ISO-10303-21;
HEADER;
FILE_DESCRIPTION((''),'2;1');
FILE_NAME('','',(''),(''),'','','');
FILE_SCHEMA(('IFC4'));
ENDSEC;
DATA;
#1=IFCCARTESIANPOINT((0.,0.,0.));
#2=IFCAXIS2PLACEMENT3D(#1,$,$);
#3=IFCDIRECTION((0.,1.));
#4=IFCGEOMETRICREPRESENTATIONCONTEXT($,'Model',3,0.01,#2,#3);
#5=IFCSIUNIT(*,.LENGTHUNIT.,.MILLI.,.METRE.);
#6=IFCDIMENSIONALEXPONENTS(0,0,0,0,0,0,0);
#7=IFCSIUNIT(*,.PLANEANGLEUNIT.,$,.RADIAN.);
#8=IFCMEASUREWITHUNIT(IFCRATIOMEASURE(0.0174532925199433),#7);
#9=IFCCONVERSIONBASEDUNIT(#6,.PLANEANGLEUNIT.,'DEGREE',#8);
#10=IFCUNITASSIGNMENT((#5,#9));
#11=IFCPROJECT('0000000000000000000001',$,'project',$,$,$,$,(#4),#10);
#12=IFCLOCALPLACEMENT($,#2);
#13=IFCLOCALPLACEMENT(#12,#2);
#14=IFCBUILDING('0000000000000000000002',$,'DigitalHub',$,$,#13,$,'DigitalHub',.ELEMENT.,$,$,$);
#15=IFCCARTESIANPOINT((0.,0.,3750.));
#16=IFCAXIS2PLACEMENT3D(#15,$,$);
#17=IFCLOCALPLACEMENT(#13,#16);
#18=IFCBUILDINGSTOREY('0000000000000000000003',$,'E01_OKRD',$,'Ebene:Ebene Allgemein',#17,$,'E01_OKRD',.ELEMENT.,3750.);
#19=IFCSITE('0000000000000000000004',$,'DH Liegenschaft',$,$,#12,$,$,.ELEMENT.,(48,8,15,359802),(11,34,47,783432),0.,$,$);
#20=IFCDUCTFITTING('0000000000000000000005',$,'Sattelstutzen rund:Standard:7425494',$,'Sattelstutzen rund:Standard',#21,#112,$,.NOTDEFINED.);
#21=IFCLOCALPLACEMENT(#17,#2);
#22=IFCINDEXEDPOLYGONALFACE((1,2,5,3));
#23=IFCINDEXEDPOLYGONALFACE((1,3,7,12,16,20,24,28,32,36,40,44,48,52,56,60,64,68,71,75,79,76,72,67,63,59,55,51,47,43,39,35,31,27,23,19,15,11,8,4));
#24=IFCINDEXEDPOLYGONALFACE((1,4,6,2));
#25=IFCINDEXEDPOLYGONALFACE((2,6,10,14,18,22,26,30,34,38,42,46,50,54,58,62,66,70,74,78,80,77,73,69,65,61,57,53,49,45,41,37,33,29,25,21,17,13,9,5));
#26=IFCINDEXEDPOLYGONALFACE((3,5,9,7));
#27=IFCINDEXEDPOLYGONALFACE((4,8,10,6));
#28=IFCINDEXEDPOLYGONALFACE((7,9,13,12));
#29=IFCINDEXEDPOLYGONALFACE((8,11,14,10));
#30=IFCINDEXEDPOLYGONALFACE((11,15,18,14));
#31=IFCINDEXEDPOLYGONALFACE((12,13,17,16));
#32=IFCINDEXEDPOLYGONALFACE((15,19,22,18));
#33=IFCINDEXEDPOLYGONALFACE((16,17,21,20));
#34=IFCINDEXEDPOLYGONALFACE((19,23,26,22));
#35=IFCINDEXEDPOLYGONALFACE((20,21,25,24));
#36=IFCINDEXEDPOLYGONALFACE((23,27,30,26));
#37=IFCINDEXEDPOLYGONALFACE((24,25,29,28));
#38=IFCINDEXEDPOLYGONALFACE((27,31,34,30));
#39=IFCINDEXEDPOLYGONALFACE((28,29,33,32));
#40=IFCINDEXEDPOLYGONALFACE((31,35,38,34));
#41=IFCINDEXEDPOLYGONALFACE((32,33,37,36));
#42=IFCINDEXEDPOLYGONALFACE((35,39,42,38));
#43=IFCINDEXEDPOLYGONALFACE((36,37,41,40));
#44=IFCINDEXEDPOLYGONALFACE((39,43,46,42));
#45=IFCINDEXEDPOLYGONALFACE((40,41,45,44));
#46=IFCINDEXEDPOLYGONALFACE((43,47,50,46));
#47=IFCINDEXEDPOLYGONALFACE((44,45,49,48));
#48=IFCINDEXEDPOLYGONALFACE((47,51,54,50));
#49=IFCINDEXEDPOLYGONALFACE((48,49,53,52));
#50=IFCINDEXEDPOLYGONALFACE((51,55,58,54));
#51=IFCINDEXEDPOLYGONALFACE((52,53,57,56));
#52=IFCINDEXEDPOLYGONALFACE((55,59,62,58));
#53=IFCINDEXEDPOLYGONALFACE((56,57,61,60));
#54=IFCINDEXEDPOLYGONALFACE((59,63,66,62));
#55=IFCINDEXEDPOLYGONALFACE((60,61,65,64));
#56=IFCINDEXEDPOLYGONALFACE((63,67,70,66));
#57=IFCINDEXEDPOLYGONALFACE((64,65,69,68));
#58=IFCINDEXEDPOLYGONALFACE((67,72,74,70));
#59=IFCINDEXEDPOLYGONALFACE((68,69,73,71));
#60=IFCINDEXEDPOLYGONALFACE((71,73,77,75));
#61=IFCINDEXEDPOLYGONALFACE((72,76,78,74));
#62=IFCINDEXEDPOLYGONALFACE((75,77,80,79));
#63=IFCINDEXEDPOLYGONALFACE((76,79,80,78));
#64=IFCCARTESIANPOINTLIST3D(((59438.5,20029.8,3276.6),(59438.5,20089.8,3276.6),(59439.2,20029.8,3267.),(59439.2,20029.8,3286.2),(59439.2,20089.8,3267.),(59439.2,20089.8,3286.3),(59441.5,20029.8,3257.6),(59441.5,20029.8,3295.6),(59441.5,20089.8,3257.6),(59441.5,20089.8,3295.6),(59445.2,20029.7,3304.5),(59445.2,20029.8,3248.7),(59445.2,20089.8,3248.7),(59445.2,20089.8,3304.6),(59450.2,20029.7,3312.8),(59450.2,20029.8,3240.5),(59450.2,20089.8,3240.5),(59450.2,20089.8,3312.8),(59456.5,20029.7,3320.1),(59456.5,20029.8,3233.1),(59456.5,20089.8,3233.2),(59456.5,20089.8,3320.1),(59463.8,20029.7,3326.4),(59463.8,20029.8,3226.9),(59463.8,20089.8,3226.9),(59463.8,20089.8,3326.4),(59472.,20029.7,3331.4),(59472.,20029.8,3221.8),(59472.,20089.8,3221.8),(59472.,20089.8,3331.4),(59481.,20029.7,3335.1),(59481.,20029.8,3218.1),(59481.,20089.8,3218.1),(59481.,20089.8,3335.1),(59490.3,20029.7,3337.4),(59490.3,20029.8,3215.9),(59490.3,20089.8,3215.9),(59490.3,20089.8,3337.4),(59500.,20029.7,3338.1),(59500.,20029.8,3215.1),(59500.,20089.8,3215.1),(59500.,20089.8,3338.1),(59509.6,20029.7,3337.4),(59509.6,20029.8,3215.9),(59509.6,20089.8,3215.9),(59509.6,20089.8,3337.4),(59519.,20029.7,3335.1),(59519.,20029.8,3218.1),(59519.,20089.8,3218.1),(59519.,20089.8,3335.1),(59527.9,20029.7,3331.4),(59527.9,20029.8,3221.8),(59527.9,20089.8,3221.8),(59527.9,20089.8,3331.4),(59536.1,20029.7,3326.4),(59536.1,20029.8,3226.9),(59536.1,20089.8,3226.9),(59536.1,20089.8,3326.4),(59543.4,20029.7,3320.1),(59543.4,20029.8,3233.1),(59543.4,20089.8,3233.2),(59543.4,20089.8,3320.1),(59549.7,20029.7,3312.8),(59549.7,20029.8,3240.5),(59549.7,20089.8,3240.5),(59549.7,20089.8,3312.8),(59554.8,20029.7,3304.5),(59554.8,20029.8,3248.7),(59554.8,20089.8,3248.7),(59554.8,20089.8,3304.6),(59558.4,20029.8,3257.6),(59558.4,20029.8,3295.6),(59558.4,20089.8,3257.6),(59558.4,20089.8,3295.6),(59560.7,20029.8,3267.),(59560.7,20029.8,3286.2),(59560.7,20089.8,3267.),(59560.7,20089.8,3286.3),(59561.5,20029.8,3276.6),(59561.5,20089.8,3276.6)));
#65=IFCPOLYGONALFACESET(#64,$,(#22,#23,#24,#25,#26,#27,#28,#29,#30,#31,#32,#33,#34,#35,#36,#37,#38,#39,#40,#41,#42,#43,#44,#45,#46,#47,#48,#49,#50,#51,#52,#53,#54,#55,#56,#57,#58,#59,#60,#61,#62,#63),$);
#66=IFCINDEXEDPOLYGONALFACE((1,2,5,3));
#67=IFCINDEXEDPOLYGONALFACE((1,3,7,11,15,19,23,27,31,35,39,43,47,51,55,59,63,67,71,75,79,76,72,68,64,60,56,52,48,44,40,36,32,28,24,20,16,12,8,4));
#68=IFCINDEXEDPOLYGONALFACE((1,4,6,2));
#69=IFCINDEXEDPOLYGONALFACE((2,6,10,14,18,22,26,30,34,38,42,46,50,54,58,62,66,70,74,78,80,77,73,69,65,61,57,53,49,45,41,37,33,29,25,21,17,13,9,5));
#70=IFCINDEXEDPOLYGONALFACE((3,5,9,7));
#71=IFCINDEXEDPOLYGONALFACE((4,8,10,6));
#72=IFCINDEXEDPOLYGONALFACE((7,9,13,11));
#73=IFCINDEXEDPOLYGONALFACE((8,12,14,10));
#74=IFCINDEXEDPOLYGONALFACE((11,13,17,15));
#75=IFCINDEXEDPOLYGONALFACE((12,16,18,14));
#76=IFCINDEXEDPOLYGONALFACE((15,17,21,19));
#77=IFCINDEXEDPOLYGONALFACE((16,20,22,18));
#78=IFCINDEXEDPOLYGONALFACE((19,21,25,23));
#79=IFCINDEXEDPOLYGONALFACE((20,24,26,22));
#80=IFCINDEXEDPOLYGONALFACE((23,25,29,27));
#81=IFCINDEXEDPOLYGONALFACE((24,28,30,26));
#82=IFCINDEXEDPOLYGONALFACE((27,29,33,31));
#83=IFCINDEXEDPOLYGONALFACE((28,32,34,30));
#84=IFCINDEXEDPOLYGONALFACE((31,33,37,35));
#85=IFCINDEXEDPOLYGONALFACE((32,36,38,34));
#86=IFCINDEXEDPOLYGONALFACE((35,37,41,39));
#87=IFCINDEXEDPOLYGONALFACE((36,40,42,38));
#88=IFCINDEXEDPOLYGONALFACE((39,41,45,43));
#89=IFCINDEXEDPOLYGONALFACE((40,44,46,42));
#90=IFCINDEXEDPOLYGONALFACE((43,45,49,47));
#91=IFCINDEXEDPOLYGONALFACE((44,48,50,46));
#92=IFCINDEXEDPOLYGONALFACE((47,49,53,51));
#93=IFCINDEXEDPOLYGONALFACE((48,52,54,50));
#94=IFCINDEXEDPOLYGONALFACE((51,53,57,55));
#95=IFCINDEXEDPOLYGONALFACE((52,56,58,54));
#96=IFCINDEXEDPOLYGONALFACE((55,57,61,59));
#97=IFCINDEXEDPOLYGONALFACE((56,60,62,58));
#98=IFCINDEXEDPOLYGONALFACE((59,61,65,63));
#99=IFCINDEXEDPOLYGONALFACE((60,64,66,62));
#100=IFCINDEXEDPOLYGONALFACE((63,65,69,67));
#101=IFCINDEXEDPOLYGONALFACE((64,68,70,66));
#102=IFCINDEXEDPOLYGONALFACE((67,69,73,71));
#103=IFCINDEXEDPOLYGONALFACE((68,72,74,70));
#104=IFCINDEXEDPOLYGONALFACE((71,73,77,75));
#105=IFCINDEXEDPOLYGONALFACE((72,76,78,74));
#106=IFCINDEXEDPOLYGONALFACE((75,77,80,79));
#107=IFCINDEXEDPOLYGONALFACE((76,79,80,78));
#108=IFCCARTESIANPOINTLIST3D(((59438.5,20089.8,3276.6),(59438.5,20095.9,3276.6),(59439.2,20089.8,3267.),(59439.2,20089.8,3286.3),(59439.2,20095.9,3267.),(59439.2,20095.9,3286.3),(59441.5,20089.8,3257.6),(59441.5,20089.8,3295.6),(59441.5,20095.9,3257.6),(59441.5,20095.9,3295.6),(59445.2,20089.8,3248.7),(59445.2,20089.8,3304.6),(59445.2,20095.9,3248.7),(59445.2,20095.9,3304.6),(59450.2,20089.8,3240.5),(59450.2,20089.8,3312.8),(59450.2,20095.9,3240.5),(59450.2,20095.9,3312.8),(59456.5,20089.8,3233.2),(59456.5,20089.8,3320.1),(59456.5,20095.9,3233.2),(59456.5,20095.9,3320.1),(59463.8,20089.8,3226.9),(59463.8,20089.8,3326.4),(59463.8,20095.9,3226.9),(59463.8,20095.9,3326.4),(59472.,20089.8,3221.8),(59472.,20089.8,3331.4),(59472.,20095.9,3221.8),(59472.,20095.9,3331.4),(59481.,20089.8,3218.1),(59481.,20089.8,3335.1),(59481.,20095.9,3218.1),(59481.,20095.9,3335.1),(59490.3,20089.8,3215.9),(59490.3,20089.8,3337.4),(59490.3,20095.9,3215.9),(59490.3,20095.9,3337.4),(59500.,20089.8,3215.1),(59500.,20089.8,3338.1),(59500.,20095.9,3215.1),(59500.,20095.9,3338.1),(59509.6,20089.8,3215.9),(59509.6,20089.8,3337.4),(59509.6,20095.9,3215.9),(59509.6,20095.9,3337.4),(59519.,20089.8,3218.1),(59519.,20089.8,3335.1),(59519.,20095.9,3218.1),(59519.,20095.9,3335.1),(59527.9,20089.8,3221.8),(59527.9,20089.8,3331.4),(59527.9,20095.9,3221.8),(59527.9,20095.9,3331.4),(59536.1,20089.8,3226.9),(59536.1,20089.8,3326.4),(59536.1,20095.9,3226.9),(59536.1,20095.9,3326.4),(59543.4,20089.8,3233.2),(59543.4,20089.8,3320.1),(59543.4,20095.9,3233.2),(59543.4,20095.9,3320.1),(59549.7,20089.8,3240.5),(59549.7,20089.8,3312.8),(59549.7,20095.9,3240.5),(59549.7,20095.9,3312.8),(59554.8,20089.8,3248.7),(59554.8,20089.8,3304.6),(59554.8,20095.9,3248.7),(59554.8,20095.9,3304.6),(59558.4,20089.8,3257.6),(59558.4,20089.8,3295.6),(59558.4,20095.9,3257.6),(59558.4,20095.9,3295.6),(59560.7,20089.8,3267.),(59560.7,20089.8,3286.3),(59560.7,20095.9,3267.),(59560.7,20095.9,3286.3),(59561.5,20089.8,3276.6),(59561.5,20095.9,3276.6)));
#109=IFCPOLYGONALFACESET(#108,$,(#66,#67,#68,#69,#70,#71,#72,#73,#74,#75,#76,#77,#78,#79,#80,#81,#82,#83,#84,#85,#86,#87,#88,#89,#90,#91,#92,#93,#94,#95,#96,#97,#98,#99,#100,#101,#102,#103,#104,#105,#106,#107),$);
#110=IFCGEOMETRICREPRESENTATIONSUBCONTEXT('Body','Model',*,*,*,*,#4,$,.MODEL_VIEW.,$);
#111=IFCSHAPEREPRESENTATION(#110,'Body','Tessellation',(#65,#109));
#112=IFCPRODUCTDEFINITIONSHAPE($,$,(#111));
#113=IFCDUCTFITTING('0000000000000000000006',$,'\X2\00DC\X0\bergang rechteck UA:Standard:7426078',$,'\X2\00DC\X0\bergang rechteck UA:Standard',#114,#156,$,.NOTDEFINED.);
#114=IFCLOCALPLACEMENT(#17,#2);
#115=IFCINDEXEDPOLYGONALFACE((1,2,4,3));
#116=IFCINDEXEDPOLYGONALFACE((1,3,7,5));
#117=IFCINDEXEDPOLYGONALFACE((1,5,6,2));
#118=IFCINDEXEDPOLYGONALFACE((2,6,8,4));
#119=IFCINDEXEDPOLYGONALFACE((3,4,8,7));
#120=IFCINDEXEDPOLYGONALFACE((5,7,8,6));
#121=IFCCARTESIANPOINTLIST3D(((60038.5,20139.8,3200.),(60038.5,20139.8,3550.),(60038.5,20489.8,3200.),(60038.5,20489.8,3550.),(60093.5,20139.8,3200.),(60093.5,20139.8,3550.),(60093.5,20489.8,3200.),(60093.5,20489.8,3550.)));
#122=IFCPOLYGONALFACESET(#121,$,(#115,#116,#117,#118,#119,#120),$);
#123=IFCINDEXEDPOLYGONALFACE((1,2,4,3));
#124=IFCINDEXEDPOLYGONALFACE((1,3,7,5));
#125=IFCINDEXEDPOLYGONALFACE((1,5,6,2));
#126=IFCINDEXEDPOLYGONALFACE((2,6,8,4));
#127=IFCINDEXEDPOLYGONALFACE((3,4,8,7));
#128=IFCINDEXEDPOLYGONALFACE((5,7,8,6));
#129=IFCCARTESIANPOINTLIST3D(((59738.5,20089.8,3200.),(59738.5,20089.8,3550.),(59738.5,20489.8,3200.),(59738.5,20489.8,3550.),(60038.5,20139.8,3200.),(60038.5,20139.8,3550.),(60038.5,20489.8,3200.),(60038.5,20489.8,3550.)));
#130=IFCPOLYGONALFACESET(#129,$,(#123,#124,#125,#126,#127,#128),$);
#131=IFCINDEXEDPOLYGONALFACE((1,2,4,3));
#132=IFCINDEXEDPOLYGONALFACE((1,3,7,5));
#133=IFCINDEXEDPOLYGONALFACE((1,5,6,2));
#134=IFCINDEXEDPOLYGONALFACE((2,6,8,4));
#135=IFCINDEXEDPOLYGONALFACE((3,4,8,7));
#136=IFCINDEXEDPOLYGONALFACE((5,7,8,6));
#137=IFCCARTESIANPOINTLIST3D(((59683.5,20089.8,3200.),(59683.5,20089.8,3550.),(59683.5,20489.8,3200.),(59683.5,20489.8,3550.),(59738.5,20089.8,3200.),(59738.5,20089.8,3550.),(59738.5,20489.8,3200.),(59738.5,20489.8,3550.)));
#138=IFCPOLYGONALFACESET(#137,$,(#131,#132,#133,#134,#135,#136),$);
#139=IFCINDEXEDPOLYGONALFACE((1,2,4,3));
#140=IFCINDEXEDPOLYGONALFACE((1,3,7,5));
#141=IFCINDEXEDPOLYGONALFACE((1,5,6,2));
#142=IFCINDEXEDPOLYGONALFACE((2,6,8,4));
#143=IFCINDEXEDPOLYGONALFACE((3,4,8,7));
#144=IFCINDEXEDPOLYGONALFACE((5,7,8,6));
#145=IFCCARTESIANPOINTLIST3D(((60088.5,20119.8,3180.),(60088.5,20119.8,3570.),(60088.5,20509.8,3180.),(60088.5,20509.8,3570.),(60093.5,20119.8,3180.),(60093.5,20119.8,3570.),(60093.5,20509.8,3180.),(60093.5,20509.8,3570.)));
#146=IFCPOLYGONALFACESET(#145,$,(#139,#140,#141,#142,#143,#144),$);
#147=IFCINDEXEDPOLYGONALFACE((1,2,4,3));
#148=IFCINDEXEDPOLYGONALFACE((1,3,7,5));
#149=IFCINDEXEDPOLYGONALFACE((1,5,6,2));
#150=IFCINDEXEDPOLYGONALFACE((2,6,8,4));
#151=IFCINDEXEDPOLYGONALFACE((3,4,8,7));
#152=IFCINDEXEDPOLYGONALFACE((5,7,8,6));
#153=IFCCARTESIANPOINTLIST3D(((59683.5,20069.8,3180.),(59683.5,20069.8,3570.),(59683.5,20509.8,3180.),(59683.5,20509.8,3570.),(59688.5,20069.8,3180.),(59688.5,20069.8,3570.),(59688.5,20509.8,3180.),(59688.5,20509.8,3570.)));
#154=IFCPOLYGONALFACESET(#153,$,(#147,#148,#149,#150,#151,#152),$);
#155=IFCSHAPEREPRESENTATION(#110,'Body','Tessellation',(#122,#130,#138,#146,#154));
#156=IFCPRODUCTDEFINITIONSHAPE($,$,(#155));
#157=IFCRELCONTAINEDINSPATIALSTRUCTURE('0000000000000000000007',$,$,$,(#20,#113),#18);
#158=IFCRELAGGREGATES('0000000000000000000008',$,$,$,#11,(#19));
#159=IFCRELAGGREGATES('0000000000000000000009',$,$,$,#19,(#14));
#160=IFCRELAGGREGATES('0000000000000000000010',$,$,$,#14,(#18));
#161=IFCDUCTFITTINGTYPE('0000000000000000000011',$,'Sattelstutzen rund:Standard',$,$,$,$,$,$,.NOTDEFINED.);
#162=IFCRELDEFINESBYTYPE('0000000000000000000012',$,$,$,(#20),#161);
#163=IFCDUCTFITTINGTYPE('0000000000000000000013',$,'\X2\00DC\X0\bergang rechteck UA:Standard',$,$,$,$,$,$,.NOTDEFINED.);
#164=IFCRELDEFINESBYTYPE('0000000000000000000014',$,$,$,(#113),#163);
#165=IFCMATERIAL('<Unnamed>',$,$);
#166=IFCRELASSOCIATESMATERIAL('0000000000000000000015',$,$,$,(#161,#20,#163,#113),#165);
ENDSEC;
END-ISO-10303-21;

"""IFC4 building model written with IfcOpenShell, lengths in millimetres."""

from ifc_helpers import new_model, entity, si_unit, converted_unit, direction, frame, origin, place, context, subcontext, project, spatial, indexed_curve, outline, extrude, source, transform, mapped, material, type_object, type_shapes, element, save


model = new_model("IFC4")

# Units and contexts
model_context = context("Model", 3, precision=0.01, world=origin(), true_north=direction((0.0, 1.0)))
body_context = subcontext(model_context, "Body", "Model", "MODEL_VIEW")
ifc_project = project(units=[si_unit("LENGTHUNIT", "METRE", prefix="MILLI"), converted_unit("PLANEANGLEUNIT", "DEGREE", entity("IfcRatioMeasure", 0.0174532925199433), si_unit("PLANEANGLEUNIT", "RADIAN"), dimensions=[0, 0, 0, 0, 0, 0, 0])], contexts=[model_context])

# Site, building, storey
site_placement = place(None, origin())
site = spatial("IfcSite", under=ifc_project, at=site_placement, Name="DH Liegenschaft", CompositionType="ELEMENT", RefLatitude=(48, 8, 15, 359802), RefLongitude=(11, 34, 47, 783432), RefElevation=0.0)
building_placement = place(site_placement, origin())
building = spatial("IfcBuilding", under=site, at=building_placement, Name="DigitalHub", LongName="DigitalHub", CompositionType="ELEMENT")
storey_placement = place(building_placement, frame((0.0, 0.0, 3750.0)))
storey = spatial("IfcBuildingStorey", under=building, at=storey_placement, Name="E01_OKRD", ObjectType="Ebene:Ebene Allgemein", LongName="E01_OKRD", CompositionType="ELEMENT", Elevation=3750.0)

# Shared definitions
ifc_material_1 = material(Name="<Unnamed>")

# Duct fittings
duct_fitting_type_1 = type_object("IfcDuctFittingType", Name="Sattelstutzen rund:Standard", PredefinedType="NOTDEFINED", material=ifc_material_1)
shared_shape_1 = source(origin(), body_context, "Body", "SweptSolid", [
    extrude(outline(indexed_curve([(0.0, -61.5), (9.6, -60.7), (19.0, -58.5), (27.9, -54.8), (36.1, -49.8), (43.5, -43.5), (49.8, -36.1), (54.8, -27.9), (58.5, -19.0), (60.7, -9.6), (61.5, 0.0), (60.7, 9.6), (58.5, 19.0), (54.8, 27.9), (49.8, 36.1), (43.5, 43.5), (36.1, 49.8), (27.9, 54.8), (19.0, 58.5), (9.6, 60.7), (0.0, 61.5), (-9.6, 60.7), (-19.0, 58.5), (-27.9, 54.8), (-36.1, 49.8), (-43.5, 43.5), (-49.8, 36.1), (-54.8, 27.9), (-58.5, 19.0), (-60.7, 9.6), (-61.5, 0.0), (-60.7, -9.6), (-58.5, -19.0), (-54.8, -27.9), (-49.8, -36.1), (-43.5, -43.5), (-36.1, -49.8), (-27.9, -54.8), (-19.0, -58.5), (-9.6, -60.7), (0.0, -61.5)], self_intersect=False)), frame((0.0, 0.0, 0.0), z_axis=(1.0, 0.0, 0.0), x_axis=(0.0, -1.0, 0.0)), (0.0, 0.0, 1.0), 60.0),
    extrude(outline(indexed_curve([(0.0, -61.5), (9.6, -60.7), (19.0, -58.5), (27.9, -54.8), (36.1, -49.8), (43.5, -43.5), (49.8, -36.1), (54.8, -27.9), (58.5, -19.0), (60.7, -9.6), (61.5, 0.0), (60.7, 9.6), (58.5, 19.0), (54.8, 27.9), (49.8, 36.1), (43.5, 43.5), (36.1, 49.8), (27.9, 54.8), (19.0, 58.5), (9.6, 60.7), (0.0, 61.5), (-9.6, 60.7), (-19.0, 58.5), (-27.9, 54.8), (-36.1, 49.8), (-43.5, 43.5), (-49.8, 36.1), (-54.8, 27.9), (-58.5, 19.0), (-60.7, 9.6), (-61.5, 0.0), (-60.7, -9.6), (-58.5, -19.0), (-54.8, -27.9), (-49.8, -36.1), (-43.5, -43.5), (-36.1, -49.8), (-27.9, -54.8), (-19.0, -58.5), (-9.6, -60.7), (0.0, -61.5)], self_intersect=False)), frame((-6.1, 0.0, 0.0), z_axis=(1.0, 0.0, 0.0), x_axis=(0.0, -1.0, 0.0)), (0.0, 0.0, 1.0), 6.1),
])
type_shapes(duct_fitting_type_1, [shared_shape_1])
duct_fitting_1_placement = place(storey_placement, frame((59500.0, 20089.8, 3276.6), z_axis=(0.0, 0.000429, -1.0), x_axis=(0.0, -1.0, -0.000429)))
element("IfcDuctFitting", 1, at=duct_fitting_1_placement, inside=storey, type_object=duct_fitting_type_1, material=ifc_material_1, Name="Sattelstutzen rund:Standard:7425494", ObjectType="Sattelstutzen rund:Standard", PredefinedType="NOTDEFINED", context=body_context, shape_type="MappedRepresentation", body=[
    mapped(shared_shape_1, transform((0.0, 0.0, 0.0), scale=1.0)),
])
duct_fitting_type_2 = type_object("IfcDuctFittingType", Name="Übergang rechteck UA:Standard", PredefinedType="NOTDEFINED", material=ifc_material_1)
shared_shape_2 = source(origin(), body_context, "Body", "SweptSolid", [
    extrude(outline(indexed_curve([(-27.5, -175.0), (27.5, -175.0), (27.5, 175.0), (-27.5, 175.0), (-27.5, -175.0)], self_intersect=False)), frame((382.5, 25.0, -175.0)), (0.0, 0.0, 1.0), 350.0),
    extrude(outline(indexed_curve([(-182.9, -184.9), (121.2, -184.9), (178.8, 160.3), (-117.1, 209.6), (-182.9, -184.9)], self_intersect=False)), frame((205.0, 12.5, -175.0), z_axis=(0.0, 0.0, 1.0), x_axis=(0.986394, 0.164399, 0.0)), (0.0, 0.0, 1.0), 350.0),
    extrude(outline(indexed_curve([(-27.5, -200.0), (27.5, -200.0), (27.5, 200.0), (-27.5, 200.0), (-27.5, -200.0)], self_intersect=False)), frame((27.5, 0.0, -175.0)), (0.0, 0.0, 1.0), 350.0),
    extrude(outline(indexed_curve([(-2.5, -195.0), (2.5, -195.0), (2.5, 195.0), (-2.5, 195.0), (-2.5, -195.0)], self_intersect=False)), frame((407.5, 25.0, -195.0)), (0.0, 0.0, 1.0), 390.0),
    extrude(outline(indexed_curve([(-2.5, -220.0), (2.5, -220.0), (2.5, 220.0), (-2.5, 220.0), (-2.5, -220.0)], self_intersect=False)), frame((2.5, 0.0, -195.0)), (0.0, 0.0, 1.0), 390.0),
])
type_shapes(duct_fitting_type_2, [shared_shape_2])
duct_fitting_2_placement = place(storey_placement, frame((59683.5, 20289.8, 3375.0)))
element("IfcDuctFitting", 2, at=duct_fitting_2_placement, inside=storey, type_object=duct_fitting_type_2, material=ifc_material_1, Name="Übergang rechteck UA:Standard:7426078", ObjectType="Übergang rechteck UA:Standard", PredefinedType="NOTDEFINED", context=body_context, shape_type="MappedRepresentation", body=[
    mapped(shared_shape_2, transform((0.0, 0.0, 0.0), scale=1.0)),
])

save(model, "model.ifc")
